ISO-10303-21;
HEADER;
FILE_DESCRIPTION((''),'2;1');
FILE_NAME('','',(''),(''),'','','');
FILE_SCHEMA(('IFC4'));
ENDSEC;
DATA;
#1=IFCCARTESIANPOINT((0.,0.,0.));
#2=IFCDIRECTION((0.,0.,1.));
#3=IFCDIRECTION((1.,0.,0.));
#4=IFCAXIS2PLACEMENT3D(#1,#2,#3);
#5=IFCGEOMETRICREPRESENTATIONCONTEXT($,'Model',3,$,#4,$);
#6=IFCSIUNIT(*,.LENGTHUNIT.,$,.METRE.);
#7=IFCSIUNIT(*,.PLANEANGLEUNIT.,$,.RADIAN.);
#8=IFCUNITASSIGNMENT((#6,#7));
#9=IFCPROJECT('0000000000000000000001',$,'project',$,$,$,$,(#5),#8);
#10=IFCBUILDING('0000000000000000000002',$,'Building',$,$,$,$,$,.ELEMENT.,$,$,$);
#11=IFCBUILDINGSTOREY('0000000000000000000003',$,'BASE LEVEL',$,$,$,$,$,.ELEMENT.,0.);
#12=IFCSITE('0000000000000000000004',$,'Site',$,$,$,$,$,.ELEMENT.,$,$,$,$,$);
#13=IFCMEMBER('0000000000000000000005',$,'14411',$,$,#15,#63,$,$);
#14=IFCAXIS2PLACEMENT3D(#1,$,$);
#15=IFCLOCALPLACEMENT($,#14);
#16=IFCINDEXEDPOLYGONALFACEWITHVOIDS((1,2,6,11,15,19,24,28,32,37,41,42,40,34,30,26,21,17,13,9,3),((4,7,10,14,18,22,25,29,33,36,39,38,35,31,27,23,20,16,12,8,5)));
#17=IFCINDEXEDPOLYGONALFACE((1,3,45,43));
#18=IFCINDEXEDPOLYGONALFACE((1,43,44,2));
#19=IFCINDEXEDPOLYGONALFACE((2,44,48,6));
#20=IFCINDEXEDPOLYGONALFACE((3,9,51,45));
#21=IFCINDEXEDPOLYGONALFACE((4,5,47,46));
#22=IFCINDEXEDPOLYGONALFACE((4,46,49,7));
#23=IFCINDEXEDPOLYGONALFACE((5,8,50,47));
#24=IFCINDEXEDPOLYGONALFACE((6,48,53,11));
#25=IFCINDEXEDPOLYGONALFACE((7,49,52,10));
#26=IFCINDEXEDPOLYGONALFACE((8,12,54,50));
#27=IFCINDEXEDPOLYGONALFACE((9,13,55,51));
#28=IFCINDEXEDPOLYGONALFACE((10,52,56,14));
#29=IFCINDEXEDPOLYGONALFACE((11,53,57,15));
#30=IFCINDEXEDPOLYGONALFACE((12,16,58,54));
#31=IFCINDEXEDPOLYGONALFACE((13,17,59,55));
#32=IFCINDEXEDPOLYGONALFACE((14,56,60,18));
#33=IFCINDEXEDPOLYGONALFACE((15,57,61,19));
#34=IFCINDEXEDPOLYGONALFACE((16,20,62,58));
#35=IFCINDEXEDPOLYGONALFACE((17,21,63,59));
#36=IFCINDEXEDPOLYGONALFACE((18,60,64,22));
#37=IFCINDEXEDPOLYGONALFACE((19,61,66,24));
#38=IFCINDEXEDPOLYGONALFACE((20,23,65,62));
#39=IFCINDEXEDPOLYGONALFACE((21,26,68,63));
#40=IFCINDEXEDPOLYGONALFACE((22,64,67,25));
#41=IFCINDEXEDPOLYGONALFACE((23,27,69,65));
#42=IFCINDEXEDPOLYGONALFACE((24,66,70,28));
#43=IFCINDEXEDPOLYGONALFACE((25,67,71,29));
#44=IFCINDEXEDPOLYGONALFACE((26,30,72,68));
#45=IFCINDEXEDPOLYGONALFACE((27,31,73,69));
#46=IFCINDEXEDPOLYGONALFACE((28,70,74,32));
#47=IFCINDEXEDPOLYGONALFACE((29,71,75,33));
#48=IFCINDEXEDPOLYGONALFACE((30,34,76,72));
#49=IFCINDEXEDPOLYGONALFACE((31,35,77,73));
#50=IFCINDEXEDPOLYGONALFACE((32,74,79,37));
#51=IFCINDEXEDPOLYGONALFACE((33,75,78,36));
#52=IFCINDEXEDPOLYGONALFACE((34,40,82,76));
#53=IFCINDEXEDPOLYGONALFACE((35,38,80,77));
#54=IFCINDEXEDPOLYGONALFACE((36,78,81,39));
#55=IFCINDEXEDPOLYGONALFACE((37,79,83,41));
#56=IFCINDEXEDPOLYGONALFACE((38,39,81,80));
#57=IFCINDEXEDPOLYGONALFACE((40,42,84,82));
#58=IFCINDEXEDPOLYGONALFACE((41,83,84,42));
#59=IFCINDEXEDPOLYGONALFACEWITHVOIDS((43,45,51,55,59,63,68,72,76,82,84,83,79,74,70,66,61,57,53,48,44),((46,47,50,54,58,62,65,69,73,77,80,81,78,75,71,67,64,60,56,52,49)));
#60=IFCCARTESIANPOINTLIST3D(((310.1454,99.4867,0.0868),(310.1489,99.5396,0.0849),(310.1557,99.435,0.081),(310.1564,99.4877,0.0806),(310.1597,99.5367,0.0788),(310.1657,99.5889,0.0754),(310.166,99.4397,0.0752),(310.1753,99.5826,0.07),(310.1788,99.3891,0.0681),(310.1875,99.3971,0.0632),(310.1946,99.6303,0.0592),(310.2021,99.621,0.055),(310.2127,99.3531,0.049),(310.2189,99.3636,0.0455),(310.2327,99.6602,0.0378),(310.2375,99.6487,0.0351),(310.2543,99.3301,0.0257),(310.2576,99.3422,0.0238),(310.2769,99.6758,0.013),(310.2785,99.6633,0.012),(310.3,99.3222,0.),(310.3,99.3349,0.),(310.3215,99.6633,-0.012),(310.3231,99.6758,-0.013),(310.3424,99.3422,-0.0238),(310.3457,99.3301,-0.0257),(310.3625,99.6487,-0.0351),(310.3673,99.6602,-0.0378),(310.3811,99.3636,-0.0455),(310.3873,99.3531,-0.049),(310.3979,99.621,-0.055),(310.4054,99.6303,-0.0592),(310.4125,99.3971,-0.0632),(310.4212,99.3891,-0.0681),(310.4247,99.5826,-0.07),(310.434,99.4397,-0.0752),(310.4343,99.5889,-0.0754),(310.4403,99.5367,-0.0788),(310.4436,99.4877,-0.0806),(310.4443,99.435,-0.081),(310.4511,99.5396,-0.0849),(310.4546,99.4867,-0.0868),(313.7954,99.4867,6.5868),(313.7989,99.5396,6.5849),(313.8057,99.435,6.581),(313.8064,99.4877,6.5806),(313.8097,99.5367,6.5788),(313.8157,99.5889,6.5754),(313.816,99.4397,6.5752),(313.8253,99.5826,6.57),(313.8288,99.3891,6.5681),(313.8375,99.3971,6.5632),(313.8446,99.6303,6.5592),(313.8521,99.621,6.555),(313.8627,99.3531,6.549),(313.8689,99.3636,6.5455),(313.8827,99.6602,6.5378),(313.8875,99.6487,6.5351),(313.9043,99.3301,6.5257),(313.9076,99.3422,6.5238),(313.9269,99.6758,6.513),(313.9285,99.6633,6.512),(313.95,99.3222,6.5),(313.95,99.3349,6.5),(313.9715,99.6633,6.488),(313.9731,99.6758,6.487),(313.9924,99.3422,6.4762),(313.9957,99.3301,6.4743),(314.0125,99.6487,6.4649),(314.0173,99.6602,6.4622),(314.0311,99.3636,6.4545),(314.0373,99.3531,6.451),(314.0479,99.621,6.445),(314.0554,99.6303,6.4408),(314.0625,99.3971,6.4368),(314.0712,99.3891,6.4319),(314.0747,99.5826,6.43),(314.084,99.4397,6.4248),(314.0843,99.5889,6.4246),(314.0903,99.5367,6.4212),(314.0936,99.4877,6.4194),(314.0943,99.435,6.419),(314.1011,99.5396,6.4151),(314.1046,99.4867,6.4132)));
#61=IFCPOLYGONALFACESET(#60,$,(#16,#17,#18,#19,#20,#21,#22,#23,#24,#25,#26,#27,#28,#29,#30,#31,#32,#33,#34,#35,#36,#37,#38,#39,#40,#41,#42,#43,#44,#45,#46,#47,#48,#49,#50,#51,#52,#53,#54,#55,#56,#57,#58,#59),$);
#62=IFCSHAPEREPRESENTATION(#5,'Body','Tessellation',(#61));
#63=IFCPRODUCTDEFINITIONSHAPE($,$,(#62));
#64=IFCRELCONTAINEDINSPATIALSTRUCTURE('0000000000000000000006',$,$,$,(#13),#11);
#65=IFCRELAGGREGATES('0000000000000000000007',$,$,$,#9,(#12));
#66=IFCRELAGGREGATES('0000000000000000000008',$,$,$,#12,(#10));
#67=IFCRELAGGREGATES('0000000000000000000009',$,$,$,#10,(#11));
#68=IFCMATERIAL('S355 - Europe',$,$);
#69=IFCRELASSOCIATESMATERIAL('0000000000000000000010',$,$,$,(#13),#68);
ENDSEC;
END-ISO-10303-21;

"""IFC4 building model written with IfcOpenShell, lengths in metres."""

from ifc_helpers import new_model, si_unit, frame, origin_with_axes, origin_2d_with_axis, place, context, project, spatial, hollow_circle, extrude, material, material_profile, profile_set, profile_usage, element, save


model = new_model("IFC4")

# Units and contexts
model_context = context("Model", 3, world=origin_with_axes())
ifc_project = project(units=[si_unit("LENGTHUNIT", "METRE"), si_unit("PLANEANGLEUNIT", "RADIAN")], contexts=[model_context])

# Site, building, storey
site = spatial("IfcSite", under=ifc_project, Name="Site", CompositionType="ELEMENT")
building = spatial("IfcBuilding", under=site, Name="Building", CompositionType="ELEMENT")
storey = spatial("IfcBuildingStorey", under=building, Name="BASE LEVEL", CompositionType="ELEMENT", Elevation=0.0)

# Shared definitions
ifc_material = material(Name="S355 - Europe")

# Member
ifc_material_profile_1 = material_profile(ifc_material, hollow_circle(Radius=0.1778, WallThickness=0.0127, at=origin_2d_with_axis()))
ifc_profile_set_1 = profile_set([ifc_material_profile_1])
ifc_profile_usage_1 = profile_usage(ifc_profile_set_1, cardinal=10)
member_1_placement = place(None, frame((313.95, 99.5, 6.5), z_axis=(-0.489624, 0.0, -0.871934), x_axis=(0.0, -1.0, 0.0)))
element("IfcMember", 1, at=member_1_placement, inside=storey, material=ifc_profile_usage_1, Name="14411", context=model_context, shape_type="SweptSolid", body=[
    extrude(hollow_circle(Radius=0.1778, WallThickness=0.0127, at=origin_2d_with_axis()), origin_with_axes(), (0.0, 0.0, 1.0), 7.4547),
])

save(model, "model.ifc")
